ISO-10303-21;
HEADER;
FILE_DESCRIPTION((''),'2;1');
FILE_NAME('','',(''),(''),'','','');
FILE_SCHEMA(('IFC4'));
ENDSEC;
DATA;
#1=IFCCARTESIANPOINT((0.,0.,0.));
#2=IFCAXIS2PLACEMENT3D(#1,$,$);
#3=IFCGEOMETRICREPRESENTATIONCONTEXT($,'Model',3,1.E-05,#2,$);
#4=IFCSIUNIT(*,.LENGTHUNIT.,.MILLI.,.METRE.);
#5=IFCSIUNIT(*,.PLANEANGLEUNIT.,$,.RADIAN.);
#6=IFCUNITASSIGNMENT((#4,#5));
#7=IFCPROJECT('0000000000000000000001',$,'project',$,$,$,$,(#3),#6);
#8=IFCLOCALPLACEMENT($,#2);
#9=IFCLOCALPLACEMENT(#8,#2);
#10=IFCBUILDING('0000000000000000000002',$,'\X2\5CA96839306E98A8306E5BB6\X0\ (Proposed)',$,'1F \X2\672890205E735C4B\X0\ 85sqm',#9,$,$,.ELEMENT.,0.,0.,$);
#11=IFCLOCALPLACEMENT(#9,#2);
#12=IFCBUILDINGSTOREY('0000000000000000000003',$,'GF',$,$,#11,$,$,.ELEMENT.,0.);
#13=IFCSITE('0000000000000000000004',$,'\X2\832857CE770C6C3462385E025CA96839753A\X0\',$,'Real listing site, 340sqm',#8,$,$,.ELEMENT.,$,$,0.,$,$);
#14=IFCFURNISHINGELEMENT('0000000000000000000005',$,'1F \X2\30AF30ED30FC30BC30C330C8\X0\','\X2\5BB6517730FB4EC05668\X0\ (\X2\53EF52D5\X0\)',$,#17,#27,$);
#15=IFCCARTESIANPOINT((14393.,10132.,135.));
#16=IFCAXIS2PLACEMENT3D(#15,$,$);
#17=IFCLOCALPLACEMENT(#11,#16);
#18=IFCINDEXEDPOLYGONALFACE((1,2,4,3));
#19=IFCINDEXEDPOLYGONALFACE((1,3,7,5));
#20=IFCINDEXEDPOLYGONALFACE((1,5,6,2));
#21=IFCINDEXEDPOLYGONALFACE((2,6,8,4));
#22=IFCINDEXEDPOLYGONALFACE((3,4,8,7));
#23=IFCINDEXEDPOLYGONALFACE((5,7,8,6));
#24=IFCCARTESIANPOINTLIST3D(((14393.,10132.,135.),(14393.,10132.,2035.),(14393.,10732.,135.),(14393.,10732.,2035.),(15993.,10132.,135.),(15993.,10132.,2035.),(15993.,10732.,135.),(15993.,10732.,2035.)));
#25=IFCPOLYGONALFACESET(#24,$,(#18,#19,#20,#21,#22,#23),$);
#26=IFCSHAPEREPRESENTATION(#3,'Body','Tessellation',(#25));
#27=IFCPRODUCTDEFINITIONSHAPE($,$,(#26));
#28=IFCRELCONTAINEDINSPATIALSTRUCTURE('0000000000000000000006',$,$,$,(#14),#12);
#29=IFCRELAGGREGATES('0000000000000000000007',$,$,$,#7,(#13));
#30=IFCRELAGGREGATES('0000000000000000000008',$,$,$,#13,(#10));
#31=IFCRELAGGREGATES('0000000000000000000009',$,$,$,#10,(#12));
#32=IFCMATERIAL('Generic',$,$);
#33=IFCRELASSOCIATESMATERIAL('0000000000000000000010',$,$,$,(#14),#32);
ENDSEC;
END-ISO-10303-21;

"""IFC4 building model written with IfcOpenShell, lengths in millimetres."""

from ifc_helpers import new_model, si_unit, frame, frame_2d, origin, place, context, project, spatial, rectangle, extrude, material, element, save


model = new_model("IFC4")

# Units and contexts
model_context = context("Model", 3, precision=1e-05, world=origin())
ifc_project = project(units=[si_unit("LENGTHUNIT", "METRE", prefix="MILLI"), si_unit("PLANEANGLEUNIT", "RADIAN")], contexts=[model_context])

# Site, building, storey
site_placement = place(None, origin())
site = spatial("IfcSite", under=ifc_project, at=site_placement, Name="茨城県水戸市岩根町", ObjectType="Real listing site, 340sqm", CompositionType="ELEMENT", RefElevation=0.0)
building_placement = place(site_placement, origin())
building = spatial("IfcBuilding", under=site, at=building_placement, Name="岩根の風の家 (Proposed)", ObjectType="1F 木造平屋 85sqm", CompositionType="ELEMENT", ElevationOfRefHeight=0.0, ElevationOfTerrain=0.0)
storey_placement = place(building_placement, origin())
storey = spatial("IfcBuildingStorey", under=building, at=storey_placement, Name="GF", CompositionType="ELEMENT", Elevation=0.0)

# Shared definitions
ifc_material_1 = material(Name="Generic")

# Furnishing element
furnishing_placement = place(storey_placement, frame((14393.0, 10132.0, 135.0)))
element("IfcFurnishingElement", 1, at=furnishing_placement, inside=storey, material=ifc_material_1, Name="1F クローゼット", Description="家具・什器 (可動)", context=model_context, shape_type="SweptSolid", body=[
    extrude(rectangle(XDim=1600.0, YDim=600.0, at=frame_2d((800.0, 300.0))), frame((14393.0, 10132.0, 135.0)), (0.0, 0.0, 1.0), 1900.0),
])

save(model, "model.ifc")
